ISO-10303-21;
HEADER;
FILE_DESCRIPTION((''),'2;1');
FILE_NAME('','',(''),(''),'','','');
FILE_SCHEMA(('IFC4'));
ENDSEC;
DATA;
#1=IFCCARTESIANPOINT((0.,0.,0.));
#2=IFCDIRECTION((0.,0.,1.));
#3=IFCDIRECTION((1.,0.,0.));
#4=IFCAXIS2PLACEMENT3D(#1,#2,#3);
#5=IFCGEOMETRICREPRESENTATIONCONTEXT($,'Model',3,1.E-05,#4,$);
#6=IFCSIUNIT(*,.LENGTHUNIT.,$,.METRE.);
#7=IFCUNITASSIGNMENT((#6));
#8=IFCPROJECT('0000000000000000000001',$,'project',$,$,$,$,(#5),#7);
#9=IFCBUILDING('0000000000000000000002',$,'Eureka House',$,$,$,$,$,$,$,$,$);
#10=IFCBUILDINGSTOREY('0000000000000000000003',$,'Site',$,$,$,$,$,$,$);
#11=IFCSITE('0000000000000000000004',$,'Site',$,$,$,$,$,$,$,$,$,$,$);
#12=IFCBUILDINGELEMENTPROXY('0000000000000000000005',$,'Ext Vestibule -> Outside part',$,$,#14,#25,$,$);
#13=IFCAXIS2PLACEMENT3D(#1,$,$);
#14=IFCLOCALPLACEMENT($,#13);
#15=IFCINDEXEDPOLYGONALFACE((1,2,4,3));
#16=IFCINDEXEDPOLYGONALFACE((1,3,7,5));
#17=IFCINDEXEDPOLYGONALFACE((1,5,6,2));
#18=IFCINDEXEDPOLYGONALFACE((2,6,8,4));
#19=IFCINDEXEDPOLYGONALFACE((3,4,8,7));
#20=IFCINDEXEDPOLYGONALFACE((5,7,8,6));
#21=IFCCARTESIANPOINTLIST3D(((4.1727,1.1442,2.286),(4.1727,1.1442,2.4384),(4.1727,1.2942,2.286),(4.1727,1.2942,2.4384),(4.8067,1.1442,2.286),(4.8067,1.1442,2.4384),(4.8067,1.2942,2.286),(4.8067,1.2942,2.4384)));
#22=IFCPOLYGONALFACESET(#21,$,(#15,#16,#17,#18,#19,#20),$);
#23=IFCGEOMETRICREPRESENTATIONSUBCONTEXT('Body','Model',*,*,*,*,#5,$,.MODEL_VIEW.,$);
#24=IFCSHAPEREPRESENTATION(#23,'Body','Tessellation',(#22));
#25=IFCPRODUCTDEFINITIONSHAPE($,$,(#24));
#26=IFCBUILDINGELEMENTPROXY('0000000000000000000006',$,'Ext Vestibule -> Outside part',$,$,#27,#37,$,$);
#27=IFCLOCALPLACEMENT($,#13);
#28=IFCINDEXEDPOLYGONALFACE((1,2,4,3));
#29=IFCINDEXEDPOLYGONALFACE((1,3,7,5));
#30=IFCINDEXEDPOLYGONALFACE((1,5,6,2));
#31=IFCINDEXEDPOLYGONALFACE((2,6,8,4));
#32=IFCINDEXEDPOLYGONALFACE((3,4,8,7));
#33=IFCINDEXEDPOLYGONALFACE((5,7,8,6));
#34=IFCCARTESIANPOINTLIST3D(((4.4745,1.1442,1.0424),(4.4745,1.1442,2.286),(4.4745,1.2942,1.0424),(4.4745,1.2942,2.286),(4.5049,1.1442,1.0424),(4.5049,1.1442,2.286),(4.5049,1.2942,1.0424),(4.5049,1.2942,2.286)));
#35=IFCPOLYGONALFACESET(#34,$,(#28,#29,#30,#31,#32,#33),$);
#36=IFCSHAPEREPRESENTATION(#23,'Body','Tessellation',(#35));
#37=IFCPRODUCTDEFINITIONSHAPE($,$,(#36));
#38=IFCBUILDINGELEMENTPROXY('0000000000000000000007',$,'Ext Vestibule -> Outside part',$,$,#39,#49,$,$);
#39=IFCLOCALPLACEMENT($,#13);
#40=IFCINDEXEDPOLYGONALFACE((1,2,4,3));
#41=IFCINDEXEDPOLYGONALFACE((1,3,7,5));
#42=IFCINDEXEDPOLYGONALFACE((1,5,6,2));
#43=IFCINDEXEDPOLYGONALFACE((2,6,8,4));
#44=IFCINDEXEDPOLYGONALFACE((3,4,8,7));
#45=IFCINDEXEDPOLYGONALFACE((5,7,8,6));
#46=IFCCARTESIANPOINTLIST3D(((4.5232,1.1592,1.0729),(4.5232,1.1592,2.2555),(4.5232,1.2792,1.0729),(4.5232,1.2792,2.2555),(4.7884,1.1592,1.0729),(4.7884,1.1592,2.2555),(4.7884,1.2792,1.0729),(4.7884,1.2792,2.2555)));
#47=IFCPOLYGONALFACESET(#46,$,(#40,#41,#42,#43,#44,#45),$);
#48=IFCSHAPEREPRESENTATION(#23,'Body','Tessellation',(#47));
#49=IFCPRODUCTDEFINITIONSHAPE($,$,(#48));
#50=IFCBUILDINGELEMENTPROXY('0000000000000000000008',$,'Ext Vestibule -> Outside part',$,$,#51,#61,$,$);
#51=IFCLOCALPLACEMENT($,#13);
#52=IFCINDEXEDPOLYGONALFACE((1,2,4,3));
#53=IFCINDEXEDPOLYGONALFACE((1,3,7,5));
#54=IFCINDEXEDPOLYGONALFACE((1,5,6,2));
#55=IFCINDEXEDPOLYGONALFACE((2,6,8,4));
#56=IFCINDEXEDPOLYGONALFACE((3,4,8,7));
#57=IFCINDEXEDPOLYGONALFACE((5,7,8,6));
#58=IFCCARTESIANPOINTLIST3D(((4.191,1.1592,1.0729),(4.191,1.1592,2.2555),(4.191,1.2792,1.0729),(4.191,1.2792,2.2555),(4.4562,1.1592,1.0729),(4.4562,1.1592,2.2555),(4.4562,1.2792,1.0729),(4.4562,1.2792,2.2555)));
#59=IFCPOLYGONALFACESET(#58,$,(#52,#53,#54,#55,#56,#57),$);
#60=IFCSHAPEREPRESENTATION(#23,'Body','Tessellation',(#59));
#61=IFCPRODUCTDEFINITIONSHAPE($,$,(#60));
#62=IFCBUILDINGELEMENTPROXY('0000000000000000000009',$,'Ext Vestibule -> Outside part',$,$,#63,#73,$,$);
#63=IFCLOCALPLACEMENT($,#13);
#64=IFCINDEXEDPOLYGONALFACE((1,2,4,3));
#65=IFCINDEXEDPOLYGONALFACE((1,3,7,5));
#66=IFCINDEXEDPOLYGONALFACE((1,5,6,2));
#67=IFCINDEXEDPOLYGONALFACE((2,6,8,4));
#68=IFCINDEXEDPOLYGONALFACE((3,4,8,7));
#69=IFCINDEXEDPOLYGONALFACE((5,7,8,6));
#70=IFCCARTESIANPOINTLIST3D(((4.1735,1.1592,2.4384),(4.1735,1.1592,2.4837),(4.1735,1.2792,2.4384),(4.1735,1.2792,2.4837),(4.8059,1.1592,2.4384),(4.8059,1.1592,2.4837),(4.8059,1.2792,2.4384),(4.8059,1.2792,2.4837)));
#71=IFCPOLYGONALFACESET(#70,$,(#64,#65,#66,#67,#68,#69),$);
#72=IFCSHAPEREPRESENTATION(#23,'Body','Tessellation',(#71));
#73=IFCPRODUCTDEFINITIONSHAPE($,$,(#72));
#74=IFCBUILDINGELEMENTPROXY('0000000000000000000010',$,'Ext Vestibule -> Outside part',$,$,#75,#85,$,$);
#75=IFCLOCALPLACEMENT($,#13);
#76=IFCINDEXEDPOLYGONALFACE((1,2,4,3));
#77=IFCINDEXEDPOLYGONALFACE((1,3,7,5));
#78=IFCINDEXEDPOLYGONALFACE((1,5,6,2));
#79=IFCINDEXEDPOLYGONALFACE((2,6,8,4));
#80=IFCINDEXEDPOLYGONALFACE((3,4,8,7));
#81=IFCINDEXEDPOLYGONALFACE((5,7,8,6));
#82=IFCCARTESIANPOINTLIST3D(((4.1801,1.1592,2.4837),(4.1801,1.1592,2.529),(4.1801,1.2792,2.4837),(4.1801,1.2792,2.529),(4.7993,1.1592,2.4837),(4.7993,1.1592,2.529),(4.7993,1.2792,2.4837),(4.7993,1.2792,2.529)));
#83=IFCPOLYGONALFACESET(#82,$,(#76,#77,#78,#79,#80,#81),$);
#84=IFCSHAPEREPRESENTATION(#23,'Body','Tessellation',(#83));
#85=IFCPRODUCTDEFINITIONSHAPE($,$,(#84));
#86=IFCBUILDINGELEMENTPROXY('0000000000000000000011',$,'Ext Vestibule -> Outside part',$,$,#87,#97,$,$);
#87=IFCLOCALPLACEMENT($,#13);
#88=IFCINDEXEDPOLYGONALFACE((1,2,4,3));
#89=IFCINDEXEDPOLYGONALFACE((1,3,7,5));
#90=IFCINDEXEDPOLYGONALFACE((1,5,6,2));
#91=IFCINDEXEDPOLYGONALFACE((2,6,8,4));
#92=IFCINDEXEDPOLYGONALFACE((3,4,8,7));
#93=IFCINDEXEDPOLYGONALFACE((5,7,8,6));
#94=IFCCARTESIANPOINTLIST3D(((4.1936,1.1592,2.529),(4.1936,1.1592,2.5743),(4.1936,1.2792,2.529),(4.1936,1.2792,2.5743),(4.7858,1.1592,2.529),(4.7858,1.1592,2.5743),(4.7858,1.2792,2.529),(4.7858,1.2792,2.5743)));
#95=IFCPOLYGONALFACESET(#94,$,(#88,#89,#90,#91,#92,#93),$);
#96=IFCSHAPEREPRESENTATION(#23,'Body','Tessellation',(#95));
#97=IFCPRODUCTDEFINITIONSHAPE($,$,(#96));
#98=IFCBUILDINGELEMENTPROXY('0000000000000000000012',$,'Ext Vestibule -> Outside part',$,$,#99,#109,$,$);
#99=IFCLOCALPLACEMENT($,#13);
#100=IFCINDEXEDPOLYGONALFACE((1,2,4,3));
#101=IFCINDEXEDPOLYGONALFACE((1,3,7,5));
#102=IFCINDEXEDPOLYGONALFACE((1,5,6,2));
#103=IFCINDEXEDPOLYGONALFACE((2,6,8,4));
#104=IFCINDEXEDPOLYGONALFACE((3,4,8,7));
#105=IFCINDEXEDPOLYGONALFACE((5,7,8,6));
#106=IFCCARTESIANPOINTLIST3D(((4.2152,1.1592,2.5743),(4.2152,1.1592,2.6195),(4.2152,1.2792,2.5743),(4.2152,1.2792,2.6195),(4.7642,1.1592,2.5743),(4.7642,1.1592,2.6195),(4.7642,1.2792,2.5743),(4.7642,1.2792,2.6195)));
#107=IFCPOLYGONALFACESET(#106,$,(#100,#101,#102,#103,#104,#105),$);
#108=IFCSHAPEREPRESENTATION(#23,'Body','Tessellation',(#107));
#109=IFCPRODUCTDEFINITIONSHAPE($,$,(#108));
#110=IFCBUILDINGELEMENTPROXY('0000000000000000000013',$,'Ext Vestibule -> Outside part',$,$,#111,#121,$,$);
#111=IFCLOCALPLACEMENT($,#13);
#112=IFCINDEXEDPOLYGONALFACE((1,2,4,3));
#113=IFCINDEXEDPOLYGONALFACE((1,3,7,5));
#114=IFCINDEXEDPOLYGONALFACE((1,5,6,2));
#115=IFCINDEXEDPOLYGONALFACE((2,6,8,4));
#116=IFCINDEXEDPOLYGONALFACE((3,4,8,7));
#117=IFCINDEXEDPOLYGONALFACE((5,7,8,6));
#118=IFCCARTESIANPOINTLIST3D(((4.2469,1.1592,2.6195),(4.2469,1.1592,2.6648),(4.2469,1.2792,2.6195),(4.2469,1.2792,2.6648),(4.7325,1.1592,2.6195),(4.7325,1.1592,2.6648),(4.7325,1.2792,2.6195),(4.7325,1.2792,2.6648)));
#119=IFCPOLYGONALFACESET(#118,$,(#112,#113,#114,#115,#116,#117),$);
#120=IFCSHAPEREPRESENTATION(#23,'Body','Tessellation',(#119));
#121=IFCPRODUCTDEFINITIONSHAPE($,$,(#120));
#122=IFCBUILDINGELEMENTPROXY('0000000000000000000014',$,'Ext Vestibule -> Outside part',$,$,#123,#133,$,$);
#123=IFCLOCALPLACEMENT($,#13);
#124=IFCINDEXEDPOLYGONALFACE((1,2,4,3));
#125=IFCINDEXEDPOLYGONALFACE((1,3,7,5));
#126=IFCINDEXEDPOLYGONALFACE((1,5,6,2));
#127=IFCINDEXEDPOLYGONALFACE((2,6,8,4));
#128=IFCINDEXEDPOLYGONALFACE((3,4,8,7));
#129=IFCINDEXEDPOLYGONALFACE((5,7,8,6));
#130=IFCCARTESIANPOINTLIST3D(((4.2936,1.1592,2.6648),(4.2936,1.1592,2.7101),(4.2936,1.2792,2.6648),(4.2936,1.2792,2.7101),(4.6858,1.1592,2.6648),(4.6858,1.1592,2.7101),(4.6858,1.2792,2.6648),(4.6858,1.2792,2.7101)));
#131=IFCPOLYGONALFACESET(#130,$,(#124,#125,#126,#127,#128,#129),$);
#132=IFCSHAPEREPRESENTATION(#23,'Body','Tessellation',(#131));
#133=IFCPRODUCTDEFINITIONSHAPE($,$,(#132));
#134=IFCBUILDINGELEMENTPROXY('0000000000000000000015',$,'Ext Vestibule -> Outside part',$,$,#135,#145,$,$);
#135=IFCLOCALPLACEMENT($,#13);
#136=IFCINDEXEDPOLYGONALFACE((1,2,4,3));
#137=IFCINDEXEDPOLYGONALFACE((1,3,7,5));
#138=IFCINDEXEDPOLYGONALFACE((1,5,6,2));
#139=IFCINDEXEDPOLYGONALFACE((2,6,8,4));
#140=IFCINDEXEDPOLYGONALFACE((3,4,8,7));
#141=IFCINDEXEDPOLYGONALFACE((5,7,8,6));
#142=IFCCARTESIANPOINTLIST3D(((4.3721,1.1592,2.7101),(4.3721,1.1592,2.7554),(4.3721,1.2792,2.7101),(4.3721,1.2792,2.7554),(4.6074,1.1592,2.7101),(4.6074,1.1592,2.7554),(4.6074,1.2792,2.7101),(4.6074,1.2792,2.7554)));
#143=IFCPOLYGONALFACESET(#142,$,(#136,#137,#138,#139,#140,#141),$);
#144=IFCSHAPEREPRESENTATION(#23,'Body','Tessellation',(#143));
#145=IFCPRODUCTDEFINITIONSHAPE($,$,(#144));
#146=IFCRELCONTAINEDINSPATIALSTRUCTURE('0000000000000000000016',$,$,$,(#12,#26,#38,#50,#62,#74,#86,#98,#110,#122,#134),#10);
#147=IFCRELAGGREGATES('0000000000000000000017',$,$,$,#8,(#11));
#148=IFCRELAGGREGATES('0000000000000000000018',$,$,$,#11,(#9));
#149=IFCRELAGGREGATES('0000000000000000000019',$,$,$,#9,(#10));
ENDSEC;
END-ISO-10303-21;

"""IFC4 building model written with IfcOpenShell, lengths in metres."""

from ifc_helpers import new_model, si_unit, frame, origin, origin_with_axes, origin_2d, place, context, subcontext, project, spatial, rectangle, extrude, element, save


model = new_model("IFC4")

# Units and contexts
model_context = context("Model", 3, precision=1e-05, world=origin_with_axes())
body_context = subcontext(model_context, "Body", "Model", "MODEL_VIEW")
ifc_project = project(units=[si_unit("LENGTHUNIT", "METRE")], contexts=[model_context])

# Site, building, storey
site = spatial("IfcSite", under=ifc_project, Name="Site")
building = spatial("IfcBuilding", under=site, Name="Eureka House")
storey = spatial("IfcBuildingStorey", under=building, Name="Site")

# Building element proxies
proxy_1_placement = place(None, frame((4.4897, 1.2192, 2.286), z_axis=(0.0, 0.0, 1.0), x_axis=(1.0, 0.0, 0.0)))
element("IfcBuildingElementProxy", 1, at=proxy_1_placement, inside=storey, Name="Ext Vestibule -> Outside part", context=body_context, shape_type="SweptSolid", body=[
    extrude(rectangle(XDim=0.634, YDim=0.15, at=origin_2d()), origin(), (0.0, 0.0, 1.0), 0.1524),
])
proxy_2_placement = place(None, frame((4.4897, 1.2192, 1.0424), z_axis=(0.0, 0.0, 1.0), x_axis=(1.0, 0.0, 0.0)))
element("IfcBuildingElementProxy", 2, at=proxy_2_placement, inside=storey, Name="Ext Vestibule -> Outside part", context=body_context, shape_type="SweptSolid", body=[
    extrude(rectangle(XDim=0.0305, YDim=0.15, at=origin_2d()), origin(), (0.0, 0.0, 1.0), 1.2436),
])
for number, where, z_axis, x_axis, name in (
    (3, (4.6558, 1.2192, 1.0729), (0.0, 0.0, 1.0), (1.0, 0.0, 0.0), "Ext Vestibule -> Outside part"),
    (4, (4.3236, 1.2192, 1.0729), (0.0, 0.0, 1.0), (1.0, 0.0, 0.0), "Ext Vestibule -> Outside part"),
):
    element("IfcBuildingElementProxy", number, at=place(None, frame(where, z_axis=z_axis, x_axis=x_axis)), inside=storey, Name=name, context=body_context, shape_type="SweptSolid", body=[
        extrude(rectangle(XDim=0.2652, YDim=0.12, at=origin_2d()), origin(), (0.0, 0.0, 1.0), 1.1826),
    ])
proxy_3_placement = place(None, frame((4.4897, 1.2192, 2.4384), z_axis=(0.0, 0.0, 1.0), x_axis=(1.0, 0.0, 0.0)))
element("IfcBuildingElementProxy", 5, at=proxy_3_placement, inside=storey, Name="Ext Vestibule -> Outside part", context=body_context, shape_type="SweptSolid", body=[
    extrude(rectangle(XDim=0.6324, YDim=0.12, at=origin_2d()), origin(), (0.0, 0.0, 1.0), 0.0453),
])
proxy_4_placement = place(None, frame((4.4897, 1.2192, 2.4837), z_axis=(0.0, 0.0, 1.0), x_axis=(1.0, 0.0, 0.0)))
element("IfcBuildingElementProxy", 6, at=proxy_4_placement, inside=storey, Name="Ext Vestibule -> Outside part", context=body_context, shape_type="SweptSolid", body=[
    extrude(rectangle(XDim=0.6193, YDim=0.12, at=origin_2d()), origin(), (0.0, 0.0, 1.0), 0.0453),
])
proxy_5_placement = place(None, frame((4.4897, 1.2192, 2.529), z_axis=(0.0, 0.0, 1.0), x_axis=(1.0, 0.0, 0.0)))
element("IfcBuildingElementProxy", 7, at=proxy_5_placement, inside=storey, Name="Ext Vestibule -> Outside part", context=body_context, shape_type="SweptSolid", body=[
    extrude(rectangle(XDim=0.5922, YDim=0.12, at=origin_2d()), origin(), (0.0, 0.0, 1.0), 0.0453),
])
proxy_6_placement = place(None, frame((4.4897, 1.2192, 2.5743), z_axis=(0.0, 0.0, 1.0), x_axis=(1.0, 0.0, 0.0)))
element("IfcBuildingElementProxy", 8, at=proxy_6_placement, inside=storey, Name="Ext Vestibule -> Outside part", context=body_context, shape_type="SweptSolid", body=[
    extrude(rectangle(XDim=0.549, YDim=0.12, at=origin_2d()), origin(), (0.0, 0.0, 1.0), 0.0453),
])
proxy_7_placement = place(None, frame((4.4897, 1.2192, 2.6195), z_axis=(0.0, 0.0, 1.0), x_axis=(1.0, 0.0, 0.0)))
element("IfcBuildingElementProxy", 9, at=proxy_7_placement, inside=storey, Name="Ext Vestibule -> Outside part", context=body_context, shape_type="SweptSolid", body=[
    extrude(rectangle(XDim=0.4856, YDim=0.12, at=origin_2d()), origin(), (0.0, 0.0, 1.0), 0.0453),
])
proxy_8_placement = place(None, frame((4.4897, 1.2192, 2.6648), z_axis=(0.0, 0.0, 1.0), x_axis=(1.0, 0.0, 0.0)))
element("IfcBuildingElementProxy", 10, at=proxy_8_placement, inside=storey, Name="Ext Vestibule -> Outside part", context=body_context, shape_type="SweptSolid", body=[
    extrude(rectangle(XDim=0.3922, YDim=0.12, at=origin_2d()), origin(), (0.0, 0.0, 1.0), 0.0453),
])
proxy_9_placement = place(None, frame((4.4897, 1.2192, 2.7101), z_axis=(0.0, 0.0, 1.0), x_axis=(1.0, 0.0, 0.0)))
element("IfcBuildingElementProxy", 11, at=proxy_9_placement, inside=storey, Name="Ext Vestibule -> Outside part", context=body_context, shape_type="SweptSolid", body=[
    extrude(rectangle(XDim=0.2353, YDim=0.12, at=origin_2d()), origin(), (0.0, 0.0, 1.0), 0.0453),
])

save(model, "model.ifc")
